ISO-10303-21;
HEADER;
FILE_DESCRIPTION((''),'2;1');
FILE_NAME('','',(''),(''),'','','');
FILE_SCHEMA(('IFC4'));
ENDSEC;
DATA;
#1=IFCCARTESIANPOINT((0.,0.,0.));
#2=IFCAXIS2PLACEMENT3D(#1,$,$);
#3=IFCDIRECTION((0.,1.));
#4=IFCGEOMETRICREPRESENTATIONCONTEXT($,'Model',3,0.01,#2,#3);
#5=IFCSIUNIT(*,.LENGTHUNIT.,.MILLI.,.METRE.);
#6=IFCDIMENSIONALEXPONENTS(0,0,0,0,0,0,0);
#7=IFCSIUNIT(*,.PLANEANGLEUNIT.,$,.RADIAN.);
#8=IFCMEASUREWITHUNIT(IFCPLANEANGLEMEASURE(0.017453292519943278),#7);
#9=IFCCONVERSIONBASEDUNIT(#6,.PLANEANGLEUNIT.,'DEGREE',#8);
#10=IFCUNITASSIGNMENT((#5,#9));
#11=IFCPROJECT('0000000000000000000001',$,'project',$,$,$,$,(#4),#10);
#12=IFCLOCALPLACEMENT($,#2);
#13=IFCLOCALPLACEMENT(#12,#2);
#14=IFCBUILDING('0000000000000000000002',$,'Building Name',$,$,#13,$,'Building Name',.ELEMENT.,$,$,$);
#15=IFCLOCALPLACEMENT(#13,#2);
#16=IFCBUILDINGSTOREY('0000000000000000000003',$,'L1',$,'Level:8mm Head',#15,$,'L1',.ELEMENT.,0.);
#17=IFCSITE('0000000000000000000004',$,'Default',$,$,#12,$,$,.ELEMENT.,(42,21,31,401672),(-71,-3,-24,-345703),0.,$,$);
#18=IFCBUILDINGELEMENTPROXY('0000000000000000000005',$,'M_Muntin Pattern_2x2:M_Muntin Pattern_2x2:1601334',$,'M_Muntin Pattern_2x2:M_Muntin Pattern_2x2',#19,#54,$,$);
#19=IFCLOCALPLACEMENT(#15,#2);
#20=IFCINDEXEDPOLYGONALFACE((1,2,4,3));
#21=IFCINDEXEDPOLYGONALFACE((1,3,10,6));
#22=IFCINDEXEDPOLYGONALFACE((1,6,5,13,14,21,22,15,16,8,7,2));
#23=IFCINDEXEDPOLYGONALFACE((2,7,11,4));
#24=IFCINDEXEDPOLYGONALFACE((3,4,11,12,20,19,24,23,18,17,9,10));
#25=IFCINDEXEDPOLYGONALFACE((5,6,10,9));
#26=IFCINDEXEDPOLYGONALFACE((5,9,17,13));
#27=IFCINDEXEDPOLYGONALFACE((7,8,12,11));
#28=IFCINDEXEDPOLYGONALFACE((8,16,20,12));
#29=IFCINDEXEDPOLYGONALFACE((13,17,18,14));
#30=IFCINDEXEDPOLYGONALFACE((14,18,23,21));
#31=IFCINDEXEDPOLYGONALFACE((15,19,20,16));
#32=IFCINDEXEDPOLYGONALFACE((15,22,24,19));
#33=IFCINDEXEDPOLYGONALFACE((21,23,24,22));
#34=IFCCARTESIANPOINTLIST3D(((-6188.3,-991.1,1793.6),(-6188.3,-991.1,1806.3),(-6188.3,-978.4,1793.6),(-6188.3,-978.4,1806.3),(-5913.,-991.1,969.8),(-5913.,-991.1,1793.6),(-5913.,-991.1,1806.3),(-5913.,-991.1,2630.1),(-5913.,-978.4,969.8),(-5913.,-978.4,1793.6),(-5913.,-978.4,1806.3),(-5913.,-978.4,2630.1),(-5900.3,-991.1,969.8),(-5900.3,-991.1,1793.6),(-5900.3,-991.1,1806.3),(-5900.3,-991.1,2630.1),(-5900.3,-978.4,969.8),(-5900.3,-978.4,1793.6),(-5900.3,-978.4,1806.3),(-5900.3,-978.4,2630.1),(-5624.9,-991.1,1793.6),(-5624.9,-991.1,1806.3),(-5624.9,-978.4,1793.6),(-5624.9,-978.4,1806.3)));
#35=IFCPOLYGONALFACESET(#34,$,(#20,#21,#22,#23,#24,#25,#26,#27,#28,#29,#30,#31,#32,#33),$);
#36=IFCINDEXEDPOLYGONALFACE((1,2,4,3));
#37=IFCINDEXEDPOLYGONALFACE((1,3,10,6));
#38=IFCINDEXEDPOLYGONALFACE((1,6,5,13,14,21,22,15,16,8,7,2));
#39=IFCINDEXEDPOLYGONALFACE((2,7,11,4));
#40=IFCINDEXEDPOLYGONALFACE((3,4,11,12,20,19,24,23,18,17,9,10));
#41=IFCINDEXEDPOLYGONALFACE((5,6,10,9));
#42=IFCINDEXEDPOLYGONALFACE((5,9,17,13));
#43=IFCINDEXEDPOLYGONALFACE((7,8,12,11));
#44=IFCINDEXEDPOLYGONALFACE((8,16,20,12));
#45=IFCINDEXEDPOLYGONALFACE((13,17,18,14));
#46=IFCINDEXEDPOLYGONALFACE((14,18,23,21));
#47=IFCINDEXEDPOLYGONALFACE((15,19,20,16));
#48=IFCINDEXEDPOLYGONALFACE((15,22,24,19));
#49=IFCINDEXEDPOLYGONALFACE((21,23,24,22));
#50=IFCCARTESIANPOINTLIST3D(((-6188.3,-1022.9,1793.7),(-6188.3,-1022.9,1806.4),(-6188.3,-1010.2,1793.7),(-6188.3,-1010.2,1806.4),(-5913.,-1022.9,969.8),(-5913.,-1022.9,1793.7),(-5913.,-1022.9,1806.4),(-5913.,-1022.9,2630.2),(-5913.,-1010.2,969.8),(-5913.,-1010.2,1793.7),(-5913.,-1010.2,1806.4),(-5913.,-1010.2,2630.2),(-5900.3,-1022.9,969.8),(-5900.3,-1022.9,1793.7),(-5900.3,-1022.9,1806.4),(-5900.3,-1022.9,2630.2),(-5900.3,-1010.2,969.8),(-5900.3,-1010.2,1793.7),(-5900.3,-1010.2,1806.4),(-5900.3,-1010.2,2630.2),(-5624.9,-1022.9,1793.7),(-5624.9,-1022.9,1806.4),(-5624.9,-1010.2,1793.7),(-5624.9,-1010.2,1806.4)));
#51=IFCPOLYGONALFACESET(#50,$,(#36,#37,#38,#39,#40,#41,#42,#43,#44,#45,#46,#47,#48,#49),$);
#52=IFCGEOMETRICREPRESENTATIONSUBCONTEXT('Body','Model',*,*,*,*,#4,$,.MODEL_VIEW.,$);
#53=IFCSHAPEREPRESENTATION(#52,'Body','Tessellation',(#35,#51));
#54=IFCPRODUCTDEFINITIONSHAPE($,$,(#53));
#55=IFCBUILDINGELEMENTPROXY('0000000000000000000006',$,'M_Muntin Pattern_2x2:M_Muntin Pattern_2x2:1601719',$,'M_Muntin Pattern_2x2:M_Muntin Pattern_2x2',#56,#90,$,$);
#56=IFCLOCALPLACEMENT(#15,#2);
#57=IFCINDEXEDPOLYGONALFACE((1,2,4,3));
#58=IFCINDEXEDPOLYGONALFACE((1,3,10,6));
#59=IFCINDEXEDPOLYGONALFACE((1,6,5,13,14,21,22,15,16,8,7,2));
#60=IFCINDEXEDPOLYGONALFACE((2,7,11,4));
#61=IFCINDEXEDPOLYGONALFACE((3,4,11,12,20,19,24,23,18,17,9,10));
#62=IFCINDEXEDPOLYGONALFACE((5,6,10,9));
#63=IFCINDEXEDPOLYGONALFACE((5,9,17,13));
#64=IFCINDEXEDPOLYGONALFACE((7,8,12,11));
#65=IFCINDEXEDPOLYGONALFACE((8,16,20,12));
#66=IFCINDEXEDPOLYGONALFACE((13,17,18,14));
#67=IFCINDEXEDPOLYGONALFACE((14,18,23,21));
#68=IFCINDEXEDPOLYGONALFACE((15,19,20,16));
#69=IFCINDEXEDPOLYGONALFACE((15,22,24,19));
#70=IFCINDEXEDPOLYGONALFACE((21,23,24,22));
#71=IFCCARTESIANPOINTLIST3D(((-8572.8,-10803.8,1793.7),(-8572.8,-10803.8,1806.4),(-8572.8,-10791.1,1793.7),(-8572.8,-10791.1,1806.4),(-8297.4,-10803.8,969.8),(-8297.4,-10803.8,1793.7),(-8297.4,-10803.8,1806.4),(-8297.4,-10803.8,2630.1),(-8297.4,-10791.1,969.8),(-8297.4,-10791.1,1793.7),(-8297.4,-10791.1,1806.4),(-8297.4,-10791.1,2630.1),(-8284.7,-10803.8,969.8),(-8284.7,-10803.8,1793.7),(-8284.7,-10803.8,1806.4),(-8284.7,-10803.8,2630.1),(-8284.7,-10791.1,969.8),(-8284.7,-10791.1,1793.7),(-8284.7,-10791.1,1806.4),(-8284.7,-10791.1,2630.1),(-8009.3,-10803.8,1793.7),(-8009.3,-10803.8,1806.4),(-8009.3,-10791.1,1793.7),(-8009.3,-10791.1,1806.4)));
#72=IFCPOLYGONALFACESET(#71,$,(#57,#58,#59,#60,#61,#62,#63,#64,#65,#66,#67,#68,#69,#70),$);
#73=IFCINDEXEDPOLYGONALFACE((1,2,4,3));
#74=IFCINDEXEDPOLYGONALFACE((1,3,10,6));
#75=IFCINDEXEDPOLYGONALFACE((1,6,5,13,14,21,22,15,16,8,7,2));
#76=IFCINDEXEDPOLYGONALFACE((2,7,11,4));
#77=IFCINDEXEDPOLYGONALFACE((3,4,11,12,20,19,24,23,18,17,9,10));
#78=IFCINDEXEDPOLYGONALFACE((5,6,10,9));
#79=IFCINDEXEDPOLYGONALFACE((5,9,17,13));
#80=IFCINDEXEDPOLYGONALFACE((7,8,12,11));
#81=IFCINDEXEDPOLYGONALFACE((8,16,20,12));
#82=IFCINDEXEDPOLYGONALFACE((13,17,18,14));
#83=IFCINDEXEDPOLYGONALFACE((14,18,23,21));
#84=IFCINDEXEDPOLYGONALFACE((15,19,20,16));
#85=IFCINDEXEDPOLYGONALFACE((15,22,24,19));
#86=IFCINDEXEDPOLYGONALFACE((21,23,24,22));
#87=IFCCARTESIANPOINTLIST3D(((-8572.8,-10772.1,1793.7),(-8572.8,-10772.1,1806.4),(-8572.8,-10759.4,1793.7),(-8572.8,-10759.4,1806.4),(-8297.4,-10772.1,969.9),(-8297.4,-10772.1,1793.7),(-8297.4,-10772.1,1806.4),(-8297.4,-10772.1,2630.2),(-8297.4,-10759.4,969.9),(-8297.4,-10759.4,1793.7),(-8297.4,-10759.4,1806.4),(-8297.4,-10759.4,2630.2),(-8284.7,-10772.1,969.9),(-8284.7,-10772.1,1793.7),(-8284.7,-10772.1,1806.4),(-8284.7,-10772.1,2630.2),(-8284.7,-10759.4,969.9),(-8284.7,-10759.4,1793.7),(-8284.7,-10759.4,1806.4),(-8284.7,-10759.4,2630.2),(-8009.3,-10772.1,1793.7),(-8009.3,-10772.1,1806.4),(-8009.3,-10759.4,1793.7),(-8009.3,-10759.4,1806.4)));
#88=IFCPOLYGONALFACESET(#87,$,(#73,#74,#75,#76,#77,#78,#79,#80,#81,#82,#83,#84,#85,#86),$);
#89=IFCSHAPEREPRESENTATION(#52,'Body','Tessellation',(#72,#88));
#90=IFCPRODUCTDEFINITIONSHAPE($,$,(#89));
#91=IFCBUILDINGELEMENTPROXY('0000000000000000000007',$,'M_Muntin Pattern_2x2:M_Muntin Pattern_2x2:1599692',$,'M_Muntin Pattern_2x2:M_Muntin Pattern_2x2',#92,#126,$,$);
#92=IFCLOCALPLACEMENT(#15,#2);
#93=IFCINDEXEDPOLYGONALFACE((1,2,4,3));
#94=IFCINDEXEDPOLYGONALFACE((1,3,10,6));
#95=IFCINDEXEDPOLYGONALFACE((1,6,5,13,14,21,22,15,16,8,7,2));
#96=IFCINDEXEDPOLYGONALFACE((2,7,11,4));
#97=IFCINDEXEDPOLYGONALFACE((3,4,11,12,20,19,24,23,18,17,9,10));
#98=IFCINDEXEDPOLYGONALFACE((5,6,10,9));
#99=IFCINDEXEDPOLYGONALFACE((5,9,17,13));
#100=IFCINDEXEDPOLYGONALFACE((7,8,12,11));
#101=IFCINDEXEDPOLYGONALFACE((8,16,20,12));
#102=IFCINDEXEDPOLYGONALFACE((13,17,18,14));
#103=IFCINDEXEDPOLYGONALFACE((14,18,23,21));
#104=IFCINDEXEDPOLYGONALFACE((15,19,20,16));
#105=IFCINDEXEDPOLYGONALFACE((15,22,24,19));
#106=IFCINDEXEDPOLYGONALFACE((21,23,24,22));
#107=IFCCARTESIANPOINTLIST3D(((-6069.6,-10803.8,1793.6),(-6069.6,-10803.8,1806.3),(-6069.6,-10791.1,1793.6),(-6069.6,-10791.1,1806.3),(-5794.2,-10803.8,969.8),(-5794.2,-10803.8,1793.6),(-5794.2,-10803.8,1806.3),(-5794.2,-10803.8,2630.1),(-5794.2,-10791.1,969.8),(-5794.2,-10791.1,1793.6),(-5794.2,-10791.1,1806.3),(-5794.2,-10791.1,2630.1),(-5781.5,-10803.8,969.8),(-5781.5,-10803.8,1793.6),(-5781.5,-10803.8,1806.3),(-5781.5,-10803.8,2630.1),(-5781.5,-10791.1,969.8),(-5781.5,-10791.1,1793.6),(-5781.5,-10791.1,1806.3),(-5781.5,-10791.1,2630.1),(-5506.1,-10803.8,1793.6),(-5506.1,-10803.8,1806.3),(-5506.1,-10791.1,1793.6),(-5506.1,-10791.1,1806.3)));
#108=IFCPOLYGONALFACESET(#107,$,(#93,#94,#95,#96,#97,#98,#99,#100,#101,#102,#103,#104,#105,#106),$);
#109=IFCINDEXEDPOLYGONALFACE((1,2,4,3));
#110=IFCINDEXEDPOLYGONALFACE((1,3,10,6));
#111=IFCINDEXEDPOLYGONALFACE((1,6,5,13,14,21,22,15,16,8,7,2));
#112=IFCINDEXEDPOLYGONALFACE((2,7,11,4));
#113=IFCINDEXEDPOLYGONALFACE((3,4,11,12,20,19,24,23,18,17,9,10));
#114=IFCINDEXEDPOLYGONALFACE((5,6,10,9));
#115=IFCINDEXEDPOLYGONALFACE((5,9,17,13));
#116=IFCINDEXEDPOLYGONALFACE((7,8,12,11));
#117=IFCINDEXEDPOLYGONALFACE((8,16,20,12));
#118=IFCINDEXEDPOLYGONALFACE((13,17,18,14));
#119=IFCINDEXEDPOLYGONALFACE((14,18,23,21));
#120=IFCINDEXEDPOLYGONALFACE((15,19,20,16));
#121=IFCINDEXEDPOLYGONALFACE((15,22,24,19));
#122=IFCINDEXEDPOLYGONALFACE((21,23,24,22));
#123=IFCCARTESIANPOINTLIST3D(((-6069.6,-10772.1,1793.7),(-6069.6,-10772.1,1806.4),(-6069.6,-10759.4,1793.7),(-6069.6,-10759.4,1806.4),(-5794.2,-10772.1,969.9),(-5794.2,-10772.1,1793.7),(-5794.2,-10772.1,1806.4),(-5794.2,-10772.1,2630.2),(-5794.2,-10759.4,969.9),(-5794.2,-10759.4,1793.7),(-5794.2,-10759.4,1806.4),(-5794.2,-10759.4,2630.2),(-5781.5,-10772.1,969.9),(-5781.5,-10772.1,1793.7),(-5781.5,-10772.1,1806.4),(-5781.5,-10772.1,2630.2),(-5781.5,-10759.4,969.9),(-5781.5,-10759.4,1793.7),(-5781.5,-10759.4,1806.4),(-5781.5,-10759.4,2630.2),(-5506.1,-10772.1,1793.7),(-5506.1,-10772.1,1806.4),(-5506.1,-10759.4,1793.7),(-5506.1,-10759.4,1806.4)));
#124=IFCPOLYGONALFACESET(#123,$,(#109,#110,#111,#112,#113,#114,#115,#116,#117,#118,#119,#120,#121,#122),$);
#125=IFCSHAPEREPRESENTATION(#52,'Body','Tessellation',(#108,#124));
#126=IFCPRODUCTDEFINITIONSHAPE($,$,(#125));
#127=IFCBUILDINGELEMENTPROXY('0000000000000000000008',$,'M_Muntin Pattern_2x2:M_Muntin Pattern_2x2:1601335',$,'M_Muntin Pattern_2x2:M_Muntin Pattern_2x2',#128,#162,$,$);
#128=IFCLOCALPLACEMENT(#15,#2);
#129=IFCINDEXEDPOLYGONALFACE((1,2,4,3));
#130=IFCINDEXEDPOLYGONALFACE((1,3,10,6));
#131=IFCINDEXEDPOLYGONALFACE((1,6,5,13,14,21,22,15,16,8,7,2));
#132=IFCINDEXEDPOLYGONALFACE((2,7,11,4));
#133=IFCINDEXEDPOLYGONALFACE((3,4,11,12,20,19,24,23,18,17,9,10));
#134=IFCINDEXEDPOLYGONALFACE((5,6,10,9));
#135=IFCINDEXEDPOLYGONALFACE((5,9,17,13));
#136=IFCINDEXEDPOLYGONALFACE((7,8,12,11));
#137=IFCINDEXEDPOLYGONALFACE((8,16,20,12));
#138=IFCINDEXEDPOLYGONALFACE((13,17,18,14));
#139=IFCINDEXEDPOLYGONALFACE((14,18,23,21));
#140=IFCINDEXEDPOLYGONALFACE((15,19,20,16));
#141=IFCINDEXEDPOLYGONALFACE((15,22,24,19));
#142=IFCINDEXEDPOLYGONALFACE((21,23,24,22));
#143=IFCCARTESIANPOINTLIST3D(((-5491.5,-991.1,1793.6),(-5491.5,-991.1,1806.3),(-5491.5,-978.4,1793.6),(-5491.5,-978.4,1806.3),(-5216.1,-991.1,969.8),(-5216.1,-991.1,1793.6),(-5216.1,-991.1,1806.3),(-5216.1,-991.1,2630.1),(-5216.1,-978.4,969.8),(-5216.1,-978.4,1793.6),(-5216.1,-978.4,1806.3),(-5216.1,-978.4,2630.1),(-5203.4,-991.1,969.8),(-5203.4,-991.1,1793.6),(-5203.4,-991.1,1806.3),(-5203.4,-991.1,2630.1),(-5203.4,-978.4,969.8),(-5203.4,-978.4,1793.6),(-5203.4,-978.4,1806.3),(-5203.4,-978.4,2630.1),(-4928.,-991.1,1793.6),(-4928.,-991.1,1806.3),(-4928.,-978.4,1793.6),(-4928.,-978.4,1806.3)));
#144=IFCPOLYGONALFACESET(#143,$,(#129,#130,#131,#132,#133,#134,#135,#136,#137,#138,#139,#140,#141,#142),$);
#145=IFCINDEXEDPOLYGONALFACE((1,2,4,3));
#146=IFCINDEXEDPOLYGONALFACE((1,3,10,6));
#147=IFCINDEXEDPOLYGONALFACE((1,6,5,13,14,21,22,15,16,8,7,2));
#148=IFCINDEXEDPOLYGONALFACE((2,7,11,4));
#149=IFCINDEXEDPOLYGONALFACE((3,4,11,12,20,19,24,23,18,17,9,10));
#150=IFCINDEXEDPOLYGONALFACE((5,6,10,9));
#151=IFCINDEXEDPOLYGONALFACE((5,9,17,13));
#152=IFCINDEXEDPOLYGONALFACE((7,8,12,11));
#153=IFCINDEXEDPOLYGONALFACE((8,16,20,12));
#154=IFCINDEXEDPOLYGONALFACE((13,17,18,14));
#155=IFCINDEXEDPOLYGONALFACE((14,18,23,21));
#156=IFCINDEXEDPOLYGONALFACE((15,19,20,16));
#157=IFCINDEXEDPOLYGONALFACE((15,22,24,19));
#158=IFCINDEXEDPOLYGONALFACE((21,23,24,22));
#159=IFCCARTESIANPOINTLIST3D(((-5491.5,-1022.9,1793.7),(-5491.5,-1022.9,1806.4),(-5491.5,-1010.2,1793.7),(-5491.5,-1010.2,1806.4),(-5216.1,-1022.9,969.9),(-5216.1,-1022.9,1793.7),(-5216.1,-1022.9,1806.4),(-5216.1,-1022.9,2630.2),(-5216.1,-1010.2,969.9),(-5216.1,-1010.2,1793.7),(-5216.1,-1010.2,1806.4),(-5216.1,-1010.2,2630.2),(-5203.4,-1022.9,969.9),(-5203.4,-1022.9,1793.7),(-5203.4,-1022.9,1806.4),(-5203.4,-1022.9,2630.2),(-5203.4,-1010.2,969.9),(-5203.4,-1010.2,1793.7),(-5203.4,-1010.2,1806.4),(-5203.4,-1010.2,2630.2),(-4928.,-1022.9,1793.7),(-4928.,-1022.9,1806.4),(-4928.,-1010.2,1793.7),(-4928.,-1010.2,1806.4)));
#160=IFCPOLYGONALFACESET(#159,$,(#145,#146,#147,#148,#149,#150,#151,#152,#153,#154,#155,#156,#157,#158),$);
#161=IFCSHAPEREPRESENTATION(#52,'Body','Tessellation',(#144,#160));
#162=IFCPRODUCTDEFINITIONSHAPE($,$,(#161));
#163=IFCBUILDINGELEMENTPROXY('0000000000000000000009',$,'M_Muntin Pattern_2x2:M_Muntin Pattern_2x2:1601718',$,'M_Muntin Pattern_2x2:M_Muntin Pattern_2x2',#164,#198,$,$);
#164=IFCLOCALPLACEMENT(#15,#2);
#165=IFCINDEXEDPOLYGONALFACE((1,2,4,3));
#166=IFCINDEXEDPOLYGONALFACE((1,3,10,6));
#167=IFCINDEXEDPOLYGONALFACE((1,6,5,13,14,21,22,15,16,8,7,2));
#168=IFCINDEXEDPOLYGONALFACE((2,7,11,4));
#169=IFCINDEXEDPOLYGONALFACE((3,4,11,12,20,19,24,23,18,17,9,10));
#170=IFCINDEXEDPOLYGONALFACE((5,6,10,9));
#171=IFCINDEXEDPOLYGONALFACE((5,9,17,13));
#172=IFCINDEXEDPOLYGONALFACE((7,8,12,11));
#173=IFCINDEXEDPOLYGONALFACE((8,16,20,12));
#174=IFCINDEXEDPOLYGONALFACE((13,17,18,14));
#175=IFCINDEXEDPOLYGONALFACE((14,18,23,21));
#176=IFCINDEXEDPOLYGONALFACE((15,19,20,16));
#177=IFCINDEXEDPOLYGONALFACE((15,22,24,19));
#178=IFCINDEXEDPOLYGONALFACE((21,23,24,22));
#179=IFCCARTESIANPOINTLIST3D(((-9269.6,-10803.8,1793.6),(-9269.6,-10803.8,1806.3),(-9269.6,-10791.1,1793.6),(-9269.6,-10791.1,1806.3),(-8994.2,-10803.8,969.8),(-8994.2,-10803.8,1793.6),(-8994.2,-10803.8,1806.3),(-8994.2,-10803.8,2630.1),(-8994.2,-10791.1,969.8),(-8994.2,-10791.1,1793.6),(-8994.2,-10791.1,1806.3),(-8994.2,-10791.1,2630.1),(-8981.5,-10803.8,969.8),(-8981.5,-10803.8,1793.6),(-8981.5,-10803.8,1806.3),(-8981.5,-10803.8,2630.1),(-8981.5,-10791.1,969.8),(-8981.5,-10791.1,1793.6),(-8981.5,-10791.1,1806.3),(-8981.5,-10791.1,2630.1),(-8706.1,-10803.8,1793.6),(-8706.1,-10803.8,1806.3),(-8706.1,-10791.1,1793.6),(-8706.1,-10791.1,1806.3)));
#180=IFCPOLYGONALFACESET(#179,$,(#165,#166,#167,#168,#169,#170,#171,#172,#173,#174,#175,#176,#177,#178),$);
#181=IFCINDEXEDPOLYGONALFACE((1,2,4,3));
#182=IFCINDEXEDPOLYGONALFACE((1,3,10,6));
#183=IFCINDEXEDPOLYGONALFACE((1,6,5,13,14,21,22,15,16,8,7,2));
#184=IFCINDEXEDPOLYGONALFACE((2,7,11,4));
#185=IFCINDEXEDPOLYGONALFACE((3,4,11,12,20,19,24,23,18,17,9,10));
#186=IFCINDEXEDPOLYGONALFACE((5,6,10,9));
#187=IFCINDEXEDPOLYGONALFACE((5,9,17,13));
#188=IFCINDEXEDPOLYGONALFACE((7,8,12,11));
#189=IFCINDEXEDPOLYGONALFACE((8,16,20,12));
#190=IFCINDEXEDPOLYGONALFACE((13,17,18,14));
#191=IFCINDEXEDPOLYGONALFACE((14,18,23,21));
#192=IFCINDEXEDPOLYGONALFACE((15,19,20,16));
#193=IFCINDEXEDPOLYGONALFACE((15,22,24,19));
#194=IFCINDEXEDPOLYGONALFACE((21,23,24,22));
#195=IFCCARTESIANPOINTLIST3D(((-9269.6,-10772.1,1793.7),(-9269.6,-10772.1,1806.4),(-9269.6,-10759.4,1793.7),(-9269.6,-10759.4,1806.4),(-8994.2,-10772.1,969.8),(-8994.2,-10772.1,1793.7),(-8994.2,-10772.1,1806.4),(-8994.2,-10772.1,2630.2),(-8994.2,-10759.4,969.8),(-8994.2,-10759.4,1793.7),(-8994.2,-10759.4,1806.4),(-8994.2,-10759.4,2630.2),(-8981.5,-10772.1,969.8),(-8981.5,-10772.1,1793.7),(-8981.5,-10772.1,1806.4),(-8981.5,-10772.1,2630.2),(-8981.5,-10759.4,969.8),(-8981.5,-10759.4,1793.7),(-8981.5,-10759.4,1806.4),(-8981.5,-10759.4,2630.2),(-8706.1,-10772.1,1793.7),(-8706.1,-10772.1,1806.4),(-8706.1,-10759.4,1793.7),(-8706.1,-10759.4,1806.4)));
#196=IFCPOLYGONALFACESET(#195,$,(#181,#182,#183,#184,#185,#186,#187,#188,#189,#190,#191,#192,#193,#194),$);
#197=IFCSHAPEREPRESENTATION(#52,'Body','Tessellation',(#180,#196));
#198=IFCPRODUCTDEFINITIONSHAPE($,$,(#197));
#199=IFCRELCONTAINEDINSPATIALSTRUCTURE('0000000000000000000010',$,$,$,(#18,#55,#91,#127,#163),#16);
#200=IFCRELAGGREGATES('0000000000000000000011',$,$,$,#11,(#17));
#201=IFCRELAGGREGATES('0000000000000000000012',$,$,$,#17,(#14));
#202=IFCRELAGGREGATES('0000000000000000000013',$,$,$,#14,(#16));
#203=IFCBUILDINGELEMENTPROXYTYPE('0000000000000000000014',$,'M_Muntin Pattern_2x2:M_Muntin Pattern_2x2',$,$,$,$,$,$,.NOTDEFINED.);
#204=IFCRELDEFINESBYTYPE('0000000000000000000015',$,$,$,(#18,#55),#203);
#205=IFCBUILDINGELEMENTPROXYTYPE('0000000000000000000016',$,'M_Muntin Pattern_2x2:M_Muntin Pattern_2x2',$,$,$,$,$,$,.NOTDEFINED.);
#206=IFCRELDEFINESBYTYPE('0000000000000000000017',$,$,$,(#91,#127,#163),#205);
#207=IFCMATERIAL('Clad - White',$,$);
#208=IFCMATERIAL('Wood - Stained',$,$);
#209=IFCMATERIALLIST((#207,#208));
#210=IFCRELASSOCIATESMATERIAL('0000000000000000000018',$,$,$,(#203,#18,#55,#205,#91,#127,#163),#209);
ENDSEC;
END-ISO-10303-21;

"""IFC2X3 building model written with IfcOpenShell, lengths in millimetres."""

from ifc_helpers import new_model, entity, si_unit, converted_unit, direction, frame, origin, place, context, subcontext, project, spatial, polyline, outline, extrude, source, transform, mapped, material, material_list, type_object, type_shapes, element, save


model = new_model("IFC2X3")

# Units and contexts
model_context = context("Model", 3, precision=0.01, world=origin(), true_north=direction((0.0, 1.0)))
body_context = subcontext(model_context, "Body", "Model", "MODEL_VIEW")
ifc_project = project(units=[si_unit("LENGTHUNIT", "METRE", prefix="MILLI"), converted_unit("PLANEANGLEUNIT", "DEGREE", entity("IfcPlaneAngleMeasure", 0.017453292519943278), si_unit("PLANEANGLEUNIT", "RADIAN"), dimensions=[0, 0, 0, 0, 0, 0, 0])], contexts=[model_context])

# Site, building, storey
site_placement = place(None, origin())
site = spatial("IfcSite", under=ifc_project, at=site_placement, Name="Default", CompositionType="ELEMENT", RefLatitude=(42, 21, 31, 401672), RefLongitude=(-71, -3, -24, -345703), RefElevation=0.0)
building_placement = place(site_placement, origin())
building = spatial("IfcBuilding", under=site, at=building_placement, Name="Building Name", LongName="Building Name", CompositionType="ELEMENT")
storey_placement = place(building_placement, origin())
storey = spatial("IfcBuildingStorey", under=building, at=storey_placement, Name="L1", ObjectType="Level:8mm Head", LongName="L1", CompositionType="ELEMENT", Elevation=0.0)

# Building element proxies
ifc_material_1 = material(Name="Clad - White")
ifc_material_2 = material(Name="Wood - Stained")
ifc_material_list = material_list([ifc_material_1, ifc_material_2])
building_element_proxy_type_1 = type_object("IfcBuildingElementProxyType", Name="M_Muntin Pattern_2x2:M_Muntin Pattern_2x2", PredefinedType="NOTDEFINED", material=ifc_material_list)
shared_shape_1 = source(origin(), body_context, "Body", "SweptSolid", [
    extrude(outline(polyline([(6.4, -6.4), (830.1, -6.4), (830.1, 6.3), (6.4, 6.3), (6.4, 281.7), (-6.3, 281.7), (-6.3, 6.3), (-830.2, 6.3), (-830.2, -6.4), (-6.3, -6.4), (-6.3, -281.7), (6.4, -281.7), (6.4, -6.4)])), frame((0.0, 9.5, 830.1), z_axis=(0.0, 1.0, 0.0), x_axis=(0.0, 0.0, 1.0)), (0.0, 0.0, 1.0), 12.7),
    extrude(outline(polyline([(6.4, -6.4), (830.2, -6.4), (830.2, 6.3), (6.4, 6.3), (6.4, 281.7), (-6.3, 281.7), (-6.3, 6.3), (-830.2, 6.3), (-830.2, -6.4), (-6.3, -6.4), (-6.3, -281.7), (6.4, -281.7), (6.4, -6.4)])), frame((0.0, -22.2, 830.2), z_axis=(0.0, 1.0, 0.0), x_axis=(0.0, 0.0, 1.0)), (0.0, 0.0, 1.0), 12.7),
])
type_shapes(building_element_proxy_type_1, [shared_shape_1])
proxy_1_placement = place(storey_placement, frame((-5906.6, -1000.6, 969.8)))
element("IfcBuildingElementProxy", 1, at=proxy_1_placement, inside=storey, type_object=building_element_proxy_type_1, material=ifc_material_list, Name="M_Muntin Pattern_2x2:M_Muntin Pattern_2x2:1601334", ObjectType="M_Muntin Pattern_2x2:M_Muntin Pattern_2x2", context=body_context, shape_type="MappedRepresentation", body=[
    mapped(shared_shape_1, transform((0.0, 0.0, 0.0), scale=1.0)),
])
proxy_2_placement = place(storey_placement, frame((-8291.0, -10781.6, 969.9), z_axis=(0.0, 0.0, 1.0), x_axis=(-1.0, 0.0, 0.0)))
element("IfcBuildingElementProxy", 2, at=proxy_2_placement, inside=storey, type_object=building_element_proxy_type_1, material=ifc_material_list, Name="M_Muntin Pattern_2x2:M_Muntin Pattern_2x2:1601719", ObjectType="M_Muntin Pattern_2x2:M_Muntin Pattern_2x2", context=body_context, shape_type="MappedRepresentation", body=[
    mapped(shared_shape_1, transform((0.0, 0.0, 0.0), scale=1.0)),
])
building_element_proxy_type_2 = type_object("IfcBuildingElementProxyType", Name="M_Muntin Pattern_2x2:M_Muntin Pattern_2x2", PredefinedType="NOTDEFINED", material=ifc_material_list)
shared_shape_2 = source(origin(), body_context, "Body", "SweptSolid", [
    extrude(outline(polyline([(6.4, -6.4), (830.1, -6.4), (830.1, 6.3), (6.4, 6.3), (6.4, 281.7), (-6.3, 281.7), (-6.3, 6.3), (-830.2, 6.3), (-830.2, -6.4), (-6.3, -6.4), (-6.3, -281.7), (6.4, -281.7), (6.4, -6.4)])), frame((0.0, -22.2, 830.1), z_axis=(0.0, 1.0, 0.0), x_axis=(0.0, 0.0, 1.0)), (0.0, 0.0, 1.0), 12.7),
    extrude(outline(polyline([(6.4, -6.4), (830.2, -6.4), (830.2, 6.3), (6.4, 6.3), (6.4, 281.7), (-6.3, 281.7), (-6.3, 6.3), (-830.2, 6.3), (-830.2, -6.4), (-6.3, -6.4), (-6.3, -281.7), (6.4, -281.7), (6.4, -6.4)])), frame((0.0, 9.5, 830.2), z_axis=(0.0, 1.0, 0.0), x_axis=(0.0, 0.0, 1.0)), (0.0, 0.0, 1.0), 12.7),
])
type_shapes(building_element_proxy_type_2, [shared_shape_2])
proxy_3_placement = place(storey_placement, frame((-5787.9, -10781.6, 969.9)))
element("IfcBuildingElementProxy", 3, at=proxy_3_placement, inside=storey, type_object=building_element_proxy_type_2, material=ifc_material_list, Name="M_Muntin Pattern_2x2:M_Muntin Pattern_2x2:1599692", ObjectType="M_Muntin Pattern_2x2:M_Muntin Pattern_2x2", context=body_context, shape_type="MappedRepresentation", body=[
    mapped(shared_shape_2, transform((0.0, 0.0, 0.0), scale=1.0)),
])
proxy_4_placement = place(storey_placement, frame((-5209.8, -1000.6, 969.9), z_axis=(0.0, 0.0, 1.0), x_axis=(-1.0, 0.0, 0.0)))
element("IfcBuildingElementProxy", 4, at=proxy_4_placement, inside=storey, type_object=building_element_proxy_type_2, material=ifc_material_list, Name="M_Muntin Pattern_2x2:M_Muntin Pattern_2x2:1601335", ObjectType="M_Muntin Pattern_2x2:M_Muntin Pattern_2x2", context=body_context, shape_type="MappedRepresentation", body=[
    mapped(shared_shape_2, transform((0.0, 0.0, 0.0), scale=1.0)),
])
proxy_5_placement = place(storey_placement, frame((-8987.9, -10781.6, 969.8)))
element("IfcBuildingElementProxy", 5, at=proxy_5_placement, inside=storey, type_object=building_element_proxy_type_2, material=ifc_material_list, Name="M_Muntin Pattern_2x2:M_Muntin Pattern_2x2:1601718", ObjectType="M_Muntin Pattern_2x2:M_Muntin Pattern_2x2", context=body_context, shape_type="MappedRepresentation", body=[
    mapped(shared_shape_2, transform((0.0, 0.0, 0.0), scale=1.0)),
])

save(model, "model.ifc")
